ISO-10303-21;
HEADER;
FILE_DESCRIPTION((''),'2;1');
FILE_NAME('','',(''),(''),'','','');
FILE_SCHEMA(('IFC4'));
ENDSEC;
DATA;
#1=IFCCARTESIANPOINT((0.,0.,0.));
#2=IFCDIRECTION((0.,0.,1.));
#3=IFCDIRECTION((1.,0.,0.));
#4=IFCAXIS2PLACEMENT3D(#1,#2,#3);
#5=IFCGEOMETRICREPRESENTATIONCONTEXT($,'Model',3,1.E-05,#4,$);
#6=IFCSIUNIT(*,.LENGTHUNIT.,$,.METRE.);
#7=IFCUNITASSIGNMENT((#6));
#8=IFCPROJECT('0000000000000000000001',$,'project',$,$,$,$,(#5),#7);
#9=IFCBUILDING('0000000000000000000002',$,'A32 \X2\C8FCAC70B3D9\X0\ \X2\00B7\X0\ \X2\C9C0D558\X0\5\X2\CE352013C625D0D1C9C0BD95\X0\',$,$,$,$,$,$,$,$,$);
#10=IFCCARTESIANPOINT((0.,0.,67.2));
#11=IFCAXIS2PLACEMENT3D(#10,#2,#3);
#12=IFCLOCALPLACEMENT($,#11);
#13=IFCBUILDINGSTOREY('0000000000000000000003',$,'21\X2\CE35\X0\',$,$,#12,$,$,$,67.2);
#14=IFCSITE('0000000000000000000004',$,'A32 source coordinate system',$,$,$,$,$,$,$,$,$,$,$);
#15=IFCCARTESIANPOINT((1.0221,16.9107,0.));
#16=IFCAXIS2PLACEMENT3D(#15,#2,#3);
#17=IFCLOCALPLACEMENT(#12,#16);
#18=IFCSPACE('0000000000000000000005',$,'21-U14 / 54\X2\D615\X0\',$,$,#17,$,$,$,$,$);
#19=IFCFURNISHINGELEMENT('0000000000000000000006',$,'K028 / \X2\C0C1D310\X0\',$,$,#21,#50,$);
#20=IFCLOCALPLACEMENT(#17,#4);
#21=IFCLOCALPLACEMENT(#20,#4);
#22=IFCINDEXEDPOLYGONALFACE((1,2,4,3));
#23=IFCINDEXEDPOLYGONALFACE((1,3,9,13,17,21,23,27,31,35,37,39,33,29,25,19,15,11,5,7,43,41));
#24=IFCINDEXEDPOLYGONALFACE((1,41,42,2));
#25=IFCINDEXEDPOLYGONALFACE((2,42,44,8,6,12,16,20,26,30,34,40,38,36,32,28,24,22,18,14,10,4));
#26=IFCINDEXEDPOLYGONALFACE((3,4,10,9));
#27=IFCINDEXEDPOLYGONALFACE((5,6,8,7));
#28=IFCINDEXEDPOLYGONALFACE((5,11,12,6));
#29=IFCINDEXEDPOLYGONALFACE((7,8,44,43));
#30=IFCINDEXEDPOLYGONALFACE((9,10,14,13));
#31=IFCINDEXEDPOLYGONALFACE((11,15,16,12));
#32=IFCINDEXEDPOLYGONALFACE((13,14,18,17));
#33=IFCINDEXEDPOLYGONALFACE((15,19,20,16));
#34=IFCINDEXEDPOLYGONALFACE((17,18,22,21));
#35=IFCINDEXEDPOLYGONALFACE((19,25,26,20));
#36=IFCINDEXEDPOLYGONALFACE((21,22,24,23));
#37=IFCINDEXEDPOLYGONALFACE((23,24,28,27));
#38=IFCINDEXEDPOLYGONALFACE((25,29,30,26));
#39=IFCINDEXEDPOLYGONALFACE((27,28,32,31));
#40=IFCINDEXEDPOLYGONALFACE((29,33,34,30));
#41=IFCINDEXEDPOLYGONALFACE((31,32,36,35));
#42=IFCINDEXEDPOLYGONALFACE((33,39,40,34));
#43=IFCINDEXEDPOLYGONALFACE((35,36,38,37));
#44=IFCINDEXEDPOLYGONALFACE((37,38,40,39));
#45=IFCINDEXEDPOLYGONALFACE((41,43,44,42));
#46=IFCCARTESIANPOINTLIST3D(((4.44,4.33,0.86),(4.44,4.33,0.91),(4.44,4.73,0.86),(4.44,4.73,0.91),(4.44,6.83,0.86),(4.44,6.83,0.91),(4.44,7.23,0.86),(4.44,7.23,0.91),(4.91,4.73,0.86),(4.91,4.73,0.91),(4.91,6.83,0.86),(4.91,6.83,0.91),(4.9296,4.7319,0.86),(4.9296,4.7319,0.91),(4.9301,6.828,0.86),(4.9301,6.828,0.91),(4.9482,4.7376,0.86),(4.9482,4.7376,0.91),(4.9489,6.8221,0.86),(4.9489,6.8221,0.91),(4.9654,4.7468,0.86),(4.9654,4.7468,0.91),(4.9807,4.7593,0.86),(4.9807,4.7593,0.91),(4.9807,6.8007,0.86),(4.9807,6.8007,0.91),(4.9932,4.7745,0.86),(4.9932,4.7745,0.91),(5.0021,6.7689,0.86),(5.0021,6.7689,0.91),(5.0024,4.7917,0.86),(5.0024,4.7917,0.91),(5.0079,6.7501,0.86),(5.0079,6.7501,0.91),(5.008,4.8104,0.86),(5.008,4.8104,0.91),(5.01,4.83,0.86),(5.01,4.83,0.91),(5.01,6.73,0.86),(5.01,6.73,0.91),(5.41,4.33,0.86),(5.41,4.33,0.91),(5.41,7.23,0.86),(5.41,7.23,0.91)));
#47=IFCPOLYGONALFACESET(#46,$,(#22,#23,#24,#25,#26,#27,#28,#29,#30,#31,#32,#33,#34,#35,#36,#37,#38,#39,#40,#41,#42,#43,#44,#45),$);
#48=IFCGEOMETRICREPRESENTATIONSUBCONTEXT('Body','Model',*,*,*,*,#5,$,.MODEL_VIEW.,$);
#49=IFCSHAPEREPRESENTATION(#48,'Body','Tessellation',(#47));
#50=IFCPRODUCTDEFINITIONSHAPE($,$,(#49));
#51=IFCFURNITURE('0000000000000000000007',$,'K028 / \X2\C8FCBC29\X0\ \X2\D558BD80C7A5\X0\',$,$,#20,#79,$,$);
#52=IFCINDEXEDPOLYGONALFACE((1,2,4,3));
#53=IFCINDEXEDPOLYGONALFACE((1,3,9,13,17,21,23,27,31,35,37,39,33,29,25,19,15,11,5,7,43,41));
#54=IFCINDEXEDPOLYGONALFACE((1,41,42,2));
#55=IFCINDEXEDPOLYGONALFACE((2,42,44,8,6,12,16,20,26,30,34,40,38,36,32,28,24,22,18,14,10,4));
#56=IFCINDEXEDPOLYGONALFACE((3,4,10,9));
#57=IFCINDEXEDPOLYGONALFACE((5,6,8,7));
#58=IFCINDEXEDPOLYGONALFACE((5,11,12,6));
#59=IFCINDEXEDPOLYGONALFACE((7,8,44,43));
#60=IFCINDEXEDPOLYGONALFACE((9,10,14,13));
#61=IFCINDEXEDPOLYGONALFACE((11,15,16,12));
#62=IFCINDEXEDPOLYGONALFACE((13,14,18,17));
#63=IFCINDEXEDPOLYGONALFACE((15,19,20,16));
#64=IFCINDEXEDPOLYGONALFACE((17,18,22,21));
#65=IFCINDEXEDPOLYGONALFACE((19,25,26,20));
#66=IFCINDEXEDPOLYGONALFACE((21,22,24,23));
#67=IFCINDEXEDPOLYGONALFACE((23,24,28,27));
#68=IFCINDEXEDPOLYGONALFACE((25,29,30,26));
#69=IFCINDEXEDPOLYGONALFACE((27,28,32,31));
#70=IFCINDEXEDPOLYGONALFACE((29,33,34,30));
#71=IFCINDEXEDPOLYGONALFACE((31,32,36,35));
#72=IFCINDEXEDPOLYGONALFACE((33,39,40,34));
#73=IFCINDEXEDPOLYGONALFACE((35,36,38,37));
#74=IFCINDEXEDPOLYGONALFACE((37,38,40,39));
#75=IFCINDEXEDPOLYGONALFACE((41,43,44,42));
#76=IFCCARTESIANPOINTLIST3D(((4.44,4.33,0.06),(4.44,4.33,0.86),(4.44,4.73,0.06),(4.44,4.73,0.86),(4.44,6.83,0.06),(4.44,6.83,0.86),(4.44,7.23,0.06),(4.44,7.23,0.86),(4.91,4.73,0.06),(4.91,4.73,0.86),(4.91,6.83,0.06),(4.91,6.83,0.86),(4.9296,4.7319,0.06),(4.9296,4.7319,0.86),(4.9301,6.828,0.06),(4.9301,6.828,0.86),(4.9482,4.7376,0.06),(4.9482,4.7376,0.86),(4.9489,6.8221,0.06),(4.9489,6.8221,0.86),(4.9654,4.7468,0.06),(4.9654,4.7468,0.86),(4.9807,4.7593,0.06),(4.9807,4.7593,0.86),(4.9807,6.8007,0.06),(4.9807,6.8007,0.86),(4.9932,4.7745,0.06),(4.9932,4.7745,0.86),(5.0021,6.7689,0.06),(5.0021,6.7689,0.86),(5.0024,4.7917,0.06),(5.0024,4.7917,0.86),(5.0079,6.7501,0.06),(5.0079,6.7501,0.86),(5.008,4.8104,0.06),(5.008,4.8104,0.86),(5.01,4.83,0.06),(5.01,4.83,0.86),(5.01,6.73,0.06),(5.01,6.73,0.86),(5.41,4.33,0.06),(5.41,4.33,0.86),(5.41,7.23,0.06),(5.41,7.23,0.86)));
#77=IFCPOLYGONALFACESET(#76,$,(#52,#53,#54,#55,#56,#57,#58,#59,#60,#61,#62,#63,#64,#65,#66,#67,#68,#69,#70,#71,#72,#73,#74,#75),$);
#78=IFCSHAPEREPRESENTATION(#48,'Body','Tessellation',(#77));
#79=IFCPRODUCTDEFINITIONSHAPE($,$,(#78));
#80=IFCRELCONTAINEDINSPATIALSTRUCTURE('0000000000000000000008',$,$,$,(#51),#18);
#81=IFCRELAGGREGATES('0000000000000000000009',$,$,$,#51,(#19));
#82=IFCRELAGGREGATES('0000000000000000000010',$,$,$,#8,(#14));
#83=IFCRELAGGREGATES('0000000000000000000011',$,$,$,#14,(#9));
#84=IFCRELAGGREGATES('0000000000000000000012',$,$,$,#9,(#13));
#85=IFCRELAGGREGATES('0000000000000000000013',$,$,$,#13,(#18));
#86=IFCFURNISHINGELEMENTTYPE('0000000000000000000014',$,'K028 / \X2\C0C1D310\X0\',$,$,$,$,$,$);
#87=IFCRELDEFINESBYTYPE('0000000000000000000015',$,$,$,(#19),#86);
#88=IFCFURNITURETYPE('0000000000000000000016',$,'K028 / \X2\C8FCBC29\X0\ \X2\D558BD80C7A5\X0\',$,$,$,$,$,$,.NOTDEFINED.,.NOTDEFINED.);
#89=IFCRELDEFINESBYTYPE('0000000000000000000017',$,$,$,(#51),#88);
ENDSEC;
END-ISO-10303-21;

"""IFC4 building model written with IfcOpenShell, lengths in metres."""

from ifc_helpers import new_model, si_unit, frame, origin, origin_with_axes, place, context, subcontext, project, spatial, polyline, outline, extrude, source, transform, mapped, type_object, type_shapes, element, aggregate, save


model = new_model("IFC4")

# Units and contexts
model_context = context("Model", 3, precision=1e-05, world=origin_with_axes())
body_context = subcontext(model_context, "Body", "Model", "MODEL_VIEW")
ifc_project = project(units=[si_unit("LENGTHUNIT", "METRE")], contexts=[model_context])

# Site, building, storey, space
site = spatial("IfcSite", under=ifc_project, Name="A32 source coordinate system")
building = spatial("IfcBuilding", under=site, Name="A32 주거동 · 지하5층–옥탑지붕")
storey_placement = place(None, frame((0.0, 0.0, 67.2), z_axis=(0.0, 0.0, 1.0), x_axis=(1.0, 0.0, 0.0)))
storey = spatial("IfcBuildingStorey", under=building, at=storey_placement, Name="21층", Elevation=67.2)
space_placement = place(storey_placement, frame((1.0221, 16.9107, 0.0), z_axis=(0.0, 0.0, 1.0), x_axis=(1.0, 0.0, 0.0)))
space = spatial("IfcSpace", under=storey, at=space_placement, Name="21-U14 / 54형")

# Furnishing element
furnishing_element_type_1 = type_object("IfcFurnishingElementType", Name="K028 / 상판")
shared_shape_1 = source(origin(), body_context, "Body", "SweptSolid", [
    extrude(outline(polyline([(5.41, 4.33), (4.44, 4.33), (4.44, 4.73), (4.91, 4.73), (4.9296, 4.7319), (4.9482, 4.7376), (4.9654, 4.7468), (4.9807, 4.7593), (4.9932, 4.7745), (5.0024, 4.7917), (5.008, 4.8104), (5.01, 4.83), (5.01, 6.73), (5.0079, 6.7501), (5.0021, 6.7689), (4.9807, 6.8007), (4.9489, 6.8221), (4.9301, 6.828), (4.91, 6.83), (4.44, 6.83), (4.44, 7.23), (5.41, 7.23), (5.41, 4.33)])), frame((0.0, 0.0, 0.86)), (0.0, 0.0, 1.0), 0.05),
])
type_shapes(furnishing_element_type_1, [shared_shape_1])
furniture_1_placement = place(space_placement, origin_with_axes())
furnishing_1_placement = place(furniture_1_placement, origin_with_axes())
furnishing_1 = element("IfcFurnishingElement", 1, at=furnishing_1_placement, type_object=furnishing_element_type_1, Name="K028 / 상판", context=body_context, shape_type="MappedRepresentation", body=[
    mapped(shared_shape_1, transform((0.0, 0.0, 0.0), scale=1.0)),
])

# Furniture
furniture_type_1 = type_object("IfcFurnitureType", Name="K028 / 주방 하부장", AssemblyPlace="NOTDEFINED", PredefinedType="NOTDEFINED")
shared_shape_2 = source(origin(), body_context, "Body", "SweptSolid", [
    extrude(outline(polyline([(5.41, 7.23), (5.41, 4.33), (4.44, 4.33), (4.44, 4.73), (4.91, 4.73), (4.9296, 4.7319), (4.9482, 4.7376), (4.9654, 4.7468), (4.9807, 4.7593), (4.9932, 4.7745), (5.0024, 4.7917), (5.008, 4.8104), (5.01, 4.83), (5.01, 6.73), (5.0079, 6.7501), (5.0021, 6.7689), (4.9807, 6.8007), (4.9489, 6.8221), (4.9301, 6.828), (4.91, 6.83), (4.44, 6.83), (4.44, 7.23), (5.41, 7.23)])), frame((0.0, 0.0, 0.06)), (0.0, 0.0, 1.0), 0.8),
])
type_shapes(furniture_type_1, [shared_shape_2])
furniture_1 = element("IfcFurniture", 2, at=furniture_1_placement, inside=space, type_object=furniture_type_1, Name="K028 / 주방 하부장", context=body_context, shape_type="MappedRepresentation", body=[
    mapped(shared_shape_2, transform((0.0, 0.0, 0.0), scale=1.0)),
])
aggregate(furniture_1, [furnishing_1])

save(model, "model.ifc")
